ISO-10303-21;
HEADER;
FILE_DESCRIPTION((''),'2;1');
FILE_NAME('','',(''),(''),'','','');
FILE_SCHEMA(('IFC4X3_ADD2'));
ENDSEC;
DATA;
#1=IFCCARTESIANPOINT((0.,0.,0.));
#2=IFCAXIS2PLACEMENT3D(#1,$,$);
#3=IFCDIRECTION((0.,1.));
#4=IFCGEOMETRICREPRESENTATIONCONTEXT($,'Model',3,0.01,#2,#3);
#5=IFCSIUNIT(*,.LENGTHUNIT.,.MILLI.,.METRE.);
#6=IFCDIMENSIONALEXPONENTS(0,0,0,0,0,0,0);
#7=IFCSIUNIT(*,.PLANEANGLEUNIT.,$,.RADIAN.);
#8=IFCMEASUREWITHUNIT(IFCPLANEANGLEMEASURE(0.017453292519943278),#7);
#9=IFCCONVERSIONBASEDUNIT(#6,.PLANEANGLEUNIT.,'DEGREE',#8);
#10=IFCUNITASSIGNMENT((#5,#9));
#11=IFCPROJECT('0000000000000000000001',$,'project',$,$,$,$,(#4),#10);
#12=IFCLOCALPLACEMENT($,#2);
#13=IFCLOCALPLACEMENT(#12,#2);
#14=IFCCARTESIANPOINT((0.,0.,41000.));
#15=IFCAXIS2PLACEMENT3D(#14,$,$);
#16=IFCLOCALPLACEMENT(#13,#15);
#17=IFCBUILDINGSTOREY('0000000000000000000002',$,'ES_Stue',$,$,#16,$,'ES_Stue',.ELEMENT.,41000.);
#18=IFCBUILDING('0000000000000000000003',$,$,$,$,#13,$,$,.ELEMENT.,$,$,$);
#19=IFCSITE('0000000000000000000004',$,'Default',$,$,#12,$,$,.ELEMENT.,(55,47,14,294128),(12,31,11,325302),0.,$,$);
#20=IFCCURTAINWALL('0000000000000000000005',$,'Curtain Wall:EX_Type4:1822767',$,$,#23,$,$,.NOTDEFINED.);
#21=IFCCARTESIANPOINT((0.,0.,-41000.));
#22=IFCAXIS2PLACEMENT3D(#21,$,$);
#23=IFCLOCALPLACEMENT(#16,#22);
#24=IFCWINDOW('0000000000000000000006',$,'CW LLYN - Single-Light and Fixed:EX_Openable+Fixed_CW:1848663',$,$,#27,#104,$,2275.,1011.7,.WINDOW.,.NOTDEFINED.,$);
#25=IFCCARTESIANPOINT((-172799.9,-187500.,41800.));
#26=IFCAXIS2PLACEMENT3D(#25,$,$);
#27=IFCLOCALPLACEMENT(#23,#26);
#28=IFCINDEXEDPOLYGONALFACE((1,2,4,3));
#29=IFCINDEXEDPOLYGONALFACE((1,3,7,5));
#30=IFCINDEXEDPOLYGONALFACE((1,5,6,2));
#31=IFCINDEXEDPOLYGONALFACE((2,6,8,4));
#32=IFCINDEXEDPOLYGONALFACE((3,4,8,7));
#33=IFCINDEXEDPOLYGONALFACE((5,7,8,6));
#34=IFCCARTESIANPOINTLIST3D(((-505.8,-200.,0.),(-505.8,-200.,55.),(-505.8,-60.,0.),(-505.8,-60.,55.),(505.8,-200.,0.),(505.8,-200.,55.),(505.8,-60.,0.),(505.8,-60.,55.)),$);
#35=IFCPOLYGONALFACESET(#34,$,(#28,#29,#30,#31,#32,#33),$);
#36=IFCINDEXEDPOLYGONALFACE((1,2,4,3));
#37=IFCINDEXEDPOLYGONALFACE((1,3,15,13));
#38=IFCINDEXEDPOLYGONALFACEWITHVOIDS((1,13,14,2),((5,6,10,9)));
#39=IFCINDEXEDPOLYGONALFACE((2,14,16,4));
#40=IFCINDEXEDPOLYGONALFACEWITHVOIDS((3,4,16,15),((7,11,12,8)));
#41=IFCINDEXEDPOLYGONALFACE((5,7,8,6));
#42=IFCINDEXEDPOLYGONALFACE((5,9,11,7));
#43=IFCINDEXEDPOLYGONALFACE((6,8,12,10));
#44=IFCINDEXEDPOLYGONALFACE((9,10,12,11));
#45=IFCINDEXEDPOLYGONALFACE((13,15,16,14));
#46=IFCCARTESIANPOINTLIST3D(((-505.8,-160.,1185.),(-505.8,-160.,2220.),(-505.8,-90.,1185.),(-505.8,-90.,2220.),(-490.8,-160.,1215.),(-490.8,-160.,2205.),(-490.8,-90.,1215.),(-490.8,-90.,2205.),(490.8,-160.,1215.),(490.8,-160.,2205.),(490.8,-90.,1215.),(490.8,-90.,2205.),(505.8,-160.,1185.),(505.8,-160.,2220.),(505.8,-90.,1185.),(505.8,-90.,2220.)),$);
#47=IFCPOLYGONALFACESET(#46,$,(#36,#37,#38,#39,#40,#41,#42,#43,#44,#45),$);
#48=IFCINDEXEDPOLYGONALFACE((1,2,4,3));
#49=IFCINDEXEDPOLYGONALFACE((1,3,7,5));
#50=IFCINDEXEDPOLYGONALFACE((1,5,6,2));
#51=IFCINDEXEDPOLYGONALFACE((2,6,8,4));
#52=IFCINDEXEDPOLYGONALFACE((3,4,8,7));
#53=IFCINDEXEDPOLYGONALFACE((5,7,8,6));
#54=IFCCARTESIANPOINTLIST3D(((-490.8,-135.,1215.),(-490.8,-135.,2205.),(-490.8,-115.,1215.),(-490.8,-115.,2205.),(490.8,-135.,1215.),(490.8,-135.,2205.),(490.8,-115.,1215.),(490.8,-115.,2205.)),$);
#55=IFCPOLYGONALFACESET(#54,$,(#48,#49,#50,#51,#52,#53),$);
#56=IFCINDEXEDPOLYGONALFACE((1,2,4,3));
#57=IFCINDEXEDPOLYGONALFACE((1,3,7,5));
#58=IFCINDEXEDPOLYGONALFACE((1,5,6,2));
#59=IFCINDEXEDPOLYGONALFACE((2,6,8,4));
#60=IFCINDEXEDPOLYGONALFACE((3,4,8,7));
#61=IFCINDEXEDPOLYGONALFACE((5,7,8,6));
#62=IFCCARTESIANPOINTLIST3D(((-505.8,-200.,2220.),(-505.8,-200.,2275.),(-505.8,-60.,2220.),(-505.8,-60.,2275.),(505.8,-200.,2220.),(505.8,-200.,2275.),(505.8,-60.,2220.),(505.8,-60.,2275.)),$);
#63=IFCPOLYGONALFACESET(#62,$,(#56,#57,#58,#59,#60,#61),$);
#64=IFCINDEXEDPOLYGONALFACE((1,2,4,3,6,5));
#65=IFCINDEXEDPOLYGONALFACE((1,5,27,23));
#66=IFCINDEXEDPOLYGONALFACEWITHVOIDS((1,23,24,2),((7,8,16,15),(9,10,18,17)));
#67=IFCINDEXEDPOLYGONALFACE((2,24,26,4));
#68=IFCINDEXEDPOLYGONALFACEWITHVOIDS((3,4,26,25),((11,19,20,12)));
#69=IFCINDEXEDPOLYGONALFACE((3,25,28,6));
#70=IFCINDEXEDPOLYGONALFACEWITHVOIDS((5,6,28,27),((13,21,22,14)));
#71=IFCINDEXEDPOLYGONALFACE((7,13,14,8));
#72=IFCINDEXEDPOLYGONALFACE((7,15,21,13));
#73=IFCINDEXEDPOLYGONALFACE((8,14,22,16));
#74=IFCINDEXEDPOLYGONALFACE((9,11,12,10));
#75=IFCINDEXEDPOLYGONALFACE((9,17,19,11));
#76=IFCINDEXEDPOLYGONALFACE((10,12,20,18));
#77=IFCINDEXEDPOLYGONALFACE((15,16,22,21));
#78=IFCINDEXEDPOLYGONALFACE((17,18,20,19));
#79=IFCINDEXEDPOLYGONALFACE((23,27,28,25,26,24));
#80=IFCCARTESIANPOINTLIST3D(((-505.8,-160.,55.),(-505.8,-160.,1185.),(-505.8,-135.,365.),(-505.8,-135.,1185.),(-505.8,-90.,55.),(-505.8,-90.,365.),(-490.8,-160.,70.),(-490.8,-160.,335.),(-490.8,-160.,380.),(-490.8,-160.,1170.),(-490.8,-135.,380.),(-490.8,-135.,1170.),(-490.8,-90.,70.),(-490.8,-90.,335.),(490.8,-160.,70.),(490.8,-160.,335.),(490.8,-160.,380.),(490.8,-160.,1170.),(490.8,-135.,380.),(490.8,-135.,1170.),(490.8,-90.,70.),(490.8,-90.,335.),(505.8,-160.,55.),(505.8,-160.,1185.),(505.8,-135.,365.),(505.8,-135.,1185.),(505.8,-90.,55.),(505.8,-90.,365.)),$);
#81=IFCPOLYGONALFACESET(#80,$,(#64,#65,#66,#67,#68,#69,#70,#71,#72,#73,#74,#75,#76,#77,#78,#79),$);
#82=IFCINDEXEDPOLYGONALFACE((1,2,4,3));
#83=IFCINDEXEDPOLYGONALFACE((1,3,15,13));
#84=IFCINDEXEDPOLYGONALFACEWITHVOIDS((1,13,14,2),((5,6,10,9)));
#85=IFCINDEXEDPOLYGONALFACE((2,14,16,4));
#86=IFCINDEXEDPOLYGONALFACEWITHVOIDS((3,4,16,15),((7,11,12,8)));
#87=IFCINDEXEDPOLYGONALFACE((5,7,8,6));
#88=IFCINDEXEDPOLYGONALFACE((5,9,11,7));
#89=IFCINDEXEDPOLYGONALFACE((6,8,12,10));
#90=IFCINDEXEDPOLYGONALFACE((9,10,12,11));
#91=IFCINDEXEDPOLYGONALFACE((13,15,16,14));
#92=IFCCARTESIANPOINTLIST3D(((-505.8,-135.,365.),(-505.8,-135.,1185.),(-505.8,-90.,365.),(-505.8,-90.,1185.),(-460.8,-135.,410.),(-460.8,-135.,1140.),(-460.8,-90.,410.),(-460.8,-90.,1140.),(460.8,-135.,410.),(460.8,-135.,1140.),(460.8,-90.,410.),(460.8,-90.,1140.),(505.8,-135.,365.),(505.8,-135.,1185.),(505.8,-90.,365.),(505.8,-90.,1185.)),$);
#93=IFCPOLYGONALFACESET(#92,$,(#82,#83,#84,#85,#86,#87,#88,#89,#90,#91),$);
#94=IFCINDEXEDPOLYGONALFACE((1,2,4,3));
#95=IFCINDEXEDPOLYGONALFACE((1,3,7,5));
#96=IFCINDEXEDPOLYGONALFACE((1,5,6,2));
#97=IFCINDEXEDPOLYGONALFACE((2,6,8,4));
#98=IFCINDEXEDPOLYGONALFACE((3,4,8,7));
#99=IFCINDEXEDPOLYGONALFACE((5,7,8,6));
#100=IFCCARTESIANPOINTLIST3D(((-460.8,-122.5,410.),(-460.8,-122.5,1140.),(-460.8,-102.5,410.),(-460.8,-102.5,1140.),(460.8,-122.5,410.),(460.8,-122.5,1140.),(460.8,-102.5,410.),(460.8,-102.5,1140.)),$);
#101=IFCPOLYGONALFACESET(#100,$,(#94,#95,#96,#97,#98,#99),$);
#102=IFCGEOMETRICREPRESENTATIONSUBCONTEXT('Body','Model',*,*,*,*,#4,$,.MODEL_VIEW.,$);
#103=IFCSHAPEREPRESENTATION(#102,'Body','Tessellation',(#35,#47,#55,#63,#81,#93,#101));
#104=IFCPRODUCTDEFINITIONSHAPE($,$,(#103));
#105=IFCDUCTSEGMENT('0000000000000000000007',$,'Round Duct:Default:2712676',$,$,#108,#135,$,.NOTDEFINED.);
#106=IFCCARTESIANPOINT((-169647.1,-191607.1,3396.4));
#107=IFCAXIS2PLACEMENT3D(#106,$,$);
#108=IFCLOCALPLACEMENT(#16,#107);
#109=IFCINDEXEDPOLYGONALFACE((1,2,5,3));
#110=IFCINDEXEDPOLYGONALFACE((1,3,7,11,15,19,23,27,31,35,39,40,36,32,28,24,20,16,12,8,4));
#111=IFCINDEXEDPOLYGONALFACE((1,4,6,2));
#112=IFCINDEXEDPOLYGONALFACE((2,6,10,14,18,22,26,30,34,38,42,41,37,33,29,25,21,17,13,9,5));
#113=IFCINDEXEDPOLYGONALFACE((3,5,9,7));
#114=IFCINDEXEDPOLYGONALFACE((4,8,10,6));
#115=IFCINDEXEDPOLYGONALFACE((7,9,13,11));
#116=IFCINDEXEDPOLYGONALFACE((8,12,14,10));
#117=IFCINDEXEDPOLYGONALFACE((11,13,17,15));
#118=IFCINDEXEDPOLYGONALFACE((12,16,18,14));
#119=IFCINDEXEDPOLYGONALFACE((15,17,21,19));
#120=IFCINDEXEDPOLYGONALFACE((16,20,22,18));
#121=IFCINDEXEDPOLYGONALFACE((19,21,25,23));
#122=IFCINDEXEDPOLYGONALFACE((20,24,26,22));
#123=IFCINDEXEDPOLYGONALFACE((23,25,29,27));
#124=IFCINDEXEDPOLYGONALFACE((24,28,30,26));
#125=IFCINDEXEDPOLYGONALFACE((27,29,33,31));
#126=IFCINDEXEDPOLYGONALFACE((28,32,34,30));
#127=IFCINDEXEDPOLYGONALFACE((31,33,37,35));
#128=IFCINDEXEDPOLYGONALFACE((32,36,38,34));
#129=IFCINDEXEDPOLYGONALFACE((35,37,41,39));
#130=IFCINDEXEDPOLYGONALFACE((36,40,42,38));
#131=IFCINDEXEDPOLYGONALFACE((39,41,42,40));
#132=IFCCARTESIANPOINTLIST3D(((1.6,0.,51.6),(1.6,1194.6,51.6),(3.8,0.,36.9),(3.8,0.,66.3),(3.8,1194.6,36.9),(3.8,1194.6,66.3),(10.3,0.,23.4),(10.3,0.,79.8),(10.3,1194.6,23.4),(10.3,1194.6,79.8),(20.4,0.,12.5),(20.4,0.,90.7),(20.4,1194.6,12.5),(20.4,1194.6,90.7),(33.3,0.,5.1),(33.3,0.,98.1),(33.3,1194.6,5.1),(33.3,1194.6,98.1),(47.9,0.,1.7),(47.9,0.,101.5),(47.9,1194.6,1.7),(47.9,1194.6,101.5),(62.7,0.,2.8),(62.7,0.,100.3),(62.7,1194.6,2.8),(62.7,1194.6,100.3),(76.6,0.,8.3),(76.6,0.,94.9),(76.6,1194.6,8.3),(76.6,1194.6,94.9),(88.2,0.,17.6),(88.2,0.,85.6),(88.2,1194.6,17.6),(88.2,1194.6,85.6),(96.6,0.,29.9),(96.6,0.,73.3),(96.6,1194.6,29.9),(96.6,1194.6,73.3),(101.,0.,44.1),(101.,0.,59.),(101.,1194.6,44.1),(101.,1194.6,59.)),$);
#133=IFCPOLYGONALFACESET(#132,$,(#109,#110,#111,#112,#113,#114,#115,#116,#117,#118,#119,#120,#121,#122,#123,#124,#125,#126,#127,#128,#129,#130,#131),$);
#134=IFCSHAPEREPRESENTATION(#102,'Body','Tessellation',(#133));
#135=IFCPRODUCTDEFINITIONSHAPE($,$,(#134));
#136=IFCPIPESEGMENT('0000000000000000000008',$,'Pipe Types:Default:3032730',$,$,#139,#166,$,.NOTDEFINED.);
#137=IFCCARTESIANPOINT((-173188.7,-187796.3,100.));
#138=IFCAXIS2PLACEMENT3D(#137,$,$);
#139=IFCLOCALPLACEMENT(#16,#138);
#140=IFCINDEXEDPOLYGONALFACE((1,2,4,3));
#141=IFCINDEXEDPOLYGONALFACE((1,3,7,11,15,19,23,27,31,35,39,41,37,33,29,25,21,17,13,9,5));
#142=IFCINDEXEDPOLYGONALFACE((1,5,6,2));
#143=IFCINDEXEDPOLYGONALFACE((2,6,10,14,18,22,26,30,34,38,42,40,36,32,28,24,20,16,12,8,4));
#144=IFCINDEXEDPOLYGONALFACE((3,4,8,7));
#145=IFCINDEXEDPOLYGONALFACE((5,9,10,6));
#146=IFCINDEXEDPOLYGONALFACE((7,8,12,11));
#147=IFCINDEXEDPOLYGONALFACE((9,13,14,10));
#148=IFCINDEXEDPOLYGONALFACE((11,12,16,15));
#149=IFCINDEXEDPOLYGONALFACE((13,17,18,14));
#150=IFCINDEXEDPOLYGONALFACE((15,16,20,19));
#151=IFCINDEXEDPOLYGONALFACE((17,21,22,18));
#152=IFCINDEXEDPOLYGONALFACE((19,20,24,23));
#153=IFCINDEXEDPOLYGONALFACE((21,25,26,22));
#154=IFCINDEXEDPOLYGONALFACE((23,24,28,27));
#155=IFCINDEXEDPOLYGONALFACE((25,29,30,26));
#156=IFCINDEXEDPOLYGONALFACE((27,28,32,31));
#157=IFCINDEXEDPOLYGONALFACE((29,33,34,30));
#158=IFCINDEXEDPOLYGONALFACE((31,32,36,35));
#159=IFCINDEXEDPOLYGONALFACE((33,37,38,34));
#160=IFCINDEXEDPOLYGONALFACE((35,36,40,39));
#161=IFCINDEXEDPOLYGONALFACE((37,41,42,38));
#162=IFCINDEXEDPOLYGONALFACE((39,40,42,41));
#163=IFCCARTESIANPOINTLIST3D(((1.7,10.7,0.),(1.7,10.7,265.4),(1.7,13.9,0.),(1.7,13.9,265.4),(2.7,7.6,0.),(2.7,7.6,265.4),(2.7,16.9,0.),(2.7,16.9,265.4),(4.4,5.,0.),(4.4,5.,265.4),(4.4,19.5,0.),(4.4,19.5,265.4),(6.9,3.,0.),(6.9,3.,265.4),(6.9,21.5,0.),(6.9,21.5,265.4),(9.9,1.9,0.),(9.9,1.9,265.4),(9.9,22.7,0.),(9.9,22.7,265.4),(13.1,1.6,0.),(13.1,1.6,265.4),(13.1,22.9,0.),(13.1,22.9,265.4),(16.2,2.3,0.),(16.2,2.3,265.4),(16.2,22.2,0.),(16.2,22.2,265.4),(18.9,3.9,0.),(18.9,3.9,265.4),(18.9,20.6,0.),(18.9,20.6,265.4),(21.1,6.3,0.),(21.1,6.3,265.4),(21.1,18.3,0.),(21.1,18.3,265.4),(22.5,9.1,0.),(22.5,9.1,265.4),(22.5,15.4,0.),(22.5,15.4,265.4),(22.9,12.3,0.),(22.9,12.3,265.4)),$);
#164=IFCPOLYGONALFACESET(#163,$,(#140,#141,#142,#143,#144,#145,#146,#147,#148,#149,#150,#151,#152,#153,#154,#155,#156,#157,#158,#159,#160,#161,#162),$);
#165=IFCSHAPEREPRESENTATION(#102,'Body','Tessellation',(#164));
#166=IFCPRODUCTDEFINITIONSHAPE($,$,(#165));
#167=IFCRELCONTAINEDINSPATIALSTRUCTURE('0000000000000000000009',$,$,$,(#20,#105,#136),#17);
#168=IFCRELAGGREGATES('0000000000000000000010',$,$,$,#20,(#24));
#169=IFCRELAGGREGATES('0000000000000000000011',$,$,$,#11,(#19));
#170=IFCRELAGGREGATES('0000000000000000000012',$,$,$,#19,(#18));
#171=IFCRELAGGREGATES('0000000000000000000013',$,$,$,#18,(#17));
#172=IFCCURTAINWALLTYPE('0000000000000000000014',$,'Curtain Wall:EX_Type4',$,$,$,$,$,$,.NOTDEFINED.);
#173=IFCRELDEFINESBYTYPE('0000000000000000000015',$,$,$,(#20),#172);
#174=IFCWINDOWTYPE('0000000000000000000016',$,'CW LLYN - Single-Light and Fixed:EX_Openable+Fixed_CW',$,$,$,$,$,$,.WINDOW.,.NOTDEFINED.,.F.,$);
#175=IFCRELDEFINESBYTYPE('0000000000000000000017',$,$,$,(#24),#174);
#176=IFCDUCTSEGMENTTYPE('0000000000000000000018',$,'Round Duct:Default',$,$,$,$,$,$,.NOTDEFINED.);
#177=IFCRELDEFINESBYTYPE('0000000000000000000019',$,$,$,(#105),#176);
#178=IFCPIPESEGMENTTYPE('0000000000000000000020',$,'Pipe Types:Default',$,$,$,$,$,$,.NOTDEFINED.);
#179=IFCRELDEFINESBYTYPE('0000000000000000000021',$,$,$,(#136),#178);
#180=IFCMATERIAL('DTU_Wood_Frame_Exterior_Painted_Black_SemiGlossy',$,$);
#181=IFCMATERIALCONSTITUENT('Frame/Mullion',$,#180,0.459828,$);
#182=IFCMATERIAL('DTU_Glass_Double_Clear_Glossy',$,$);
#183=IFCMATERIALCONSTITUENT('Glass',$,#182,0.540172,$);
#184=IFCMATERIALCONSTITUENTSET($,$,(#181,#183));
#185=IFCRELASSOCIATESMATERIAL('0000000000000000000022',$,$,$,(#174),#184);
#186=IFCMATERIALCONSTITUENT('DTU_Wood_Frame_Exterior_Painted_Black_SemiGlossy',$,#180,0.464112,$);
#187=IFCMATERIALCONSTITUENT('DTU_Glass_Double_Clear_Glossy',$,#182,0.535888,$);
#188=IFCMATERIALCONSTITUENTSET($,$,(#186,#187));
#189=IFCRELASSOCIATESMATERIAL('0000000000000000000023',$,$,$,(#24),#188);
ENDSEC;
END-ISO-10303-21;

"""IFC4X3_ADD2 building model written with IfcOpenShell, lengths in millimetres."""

from ifc_helpers import new_model, entity, si_unit, converted_unit, direction, frame, frame_2d, origin, origin_2d_with_axis, place, context, subcontext, project, spatial, polyline, rectangle, circle, outline, extrude, source, transform, mapped, material, constituent, constituent_set, type_object, type_shapes, element, aggregate, save


model = new_model("IFC4X3_ADD2")

# Units and contexts
model_context = context("Model", 3, precision=0.01, world=origin(), true_north=direction((0.0, 1.0)))
body_context = subcontext(model_context, "Body", "Model", "MODEL_VIEW")
ifc_project = project(units=[si_unit("LENGTHUNIT", "METRE", prefix="MILLI"), converted_unit("PLANEANGLEUNIT", "DEGREE", entity("IfcPlaneAngleMeasure", 0.017453292519943278), si_unit("PLANEANGLEUNIT", "RADIAN"), dimensions=[0, 0, 0, 0, 0, 0, 0])], contexts=[model_context])

# Site, building, storey
site_placement = place(None, origin())
site = spatial("IfcSite", under=ifc_project, at=site_placement, Name="Default", CompositionType="ELEMENT", RefLatitude=(55, 47, 14, 294128), RefLongitude=(12, 31, 11, 325302), RefElevation=0.0)
building_placement = place(site_placement, origin())
building = spatial("IfcBuilding", under=site, at=building_placement, CompositionType="ELEMENT")
storey_placement = place(building_placement, frame((0.0, 0.0, 41000.0)))
storey = spatial("IfcBuildingStorey", under=building, at=storey_placement, Name="ES_Stue", LongName="ES_Stue", CompositionType="ELEMENT", Elevation=41000.0)

# Curtain wall, window, openings
curtain_wall_type = type_object("IfcCurtainWallType", Name="Curtain Wall:EX_Type4", PredefinedType="NOTDEFINED")
curtain_wall_placement = place(storey_placement, frame((0.0, 0.0, -41000.0)))
curtain_wall = element("IfcCurtainWall", 1, at=curtain_wall_placement, inside=storey, type_object=curtain_wall_type, Name="Curtain Wall:EX_Type4:1822767", PredefinedType="NOTDEFINED")
ifc_material_1 = material(Name="DTU_Wood_Frame_Exterior_Painted_Black_SemiGlossy")
ifc_material_2 = material(Name="DTU_Glass_Double_Clear_Glossy")
ifc_constituent_1 = constituent(ifc_material_1, Name="DTU_Wood_Frame_Exterior_Painted_Black_SemiGlossy", fraction=0.464112)
ifc_constituent_2 = constituent(ifc_material_2, Name="DTU_Glass_Double_Clear_Glossy", fraction=0.535888)
ifc_constituent_set_1 = constituent_set(constituents=[ifc_constituent_1, ifc_constituent_2])
ifc_constituent_3 = constituent(ifc_material_1, Name="Frame/Mullion", fraction=0.459828)
ifc_constituent_4 = constituent(ifc_material_2, Name="Glass", fraction=0.540172)
ifc_constituent_set_2 = constituent_set(constituents=[ifc_constituent_3, ifc_constituent_4])
window_type_1 = type_object("IfcWindowType", Name="CW LLYN - Single-Light and Fixed:EX_Openable+Fixed_CW", ParameterTakesPrecedence=False, PartitioningType="NOTDEFINED", PredefinedType="WINDOW", material=ifc_constituent_set_2)
shared_shape_1 = source(origin(), body_context, "Body", "SweptSolid", [
    extrude(rectangle(XDim=140.0, YDim=1011.7, at=origin_2d_with_axis()), frame((0.0, -130.0, 0.0), z_axis=(0.0, 0.0, 1.0), x_axis=(0.0, -1.0, 0.0)), (0.0, 0.0, 1.0), 55.0),
    extrude(outline(polyline([(-517.5, -505.8), (517.5, -505.8), (517.5, 505.8), (-517.5, 505.8), (-517.5, -505.8)]), holes=[polyline([(502.5, -490.8), (-487.5, -490.8), (-487.5, 490.8), (502.5, 490.8), (502.5, -490.8)])]), frame((0.0, -90.0, 1702.5), z_axis=(0.0, -1.0, 0.0), x_axis=(0.0, 0.0, 1.0)), (0.0, 0.0, 1.0), 70.0),
    extrude(rectangle(XDim=981.7, YDim=20.0, at=frame_2d((0.0, 0.0), x_axis=(1.0, 0.0))), frame((0.0, -125.0, 1215.0), z_axis=(0.0, 0.0, 1.0), x_axis=(-1.0, 0.0, 0.0)), (0.0, 0.0, 1.0), 990.0),
    extrude(rectangle(XDim=981.7, YDim=20.0, at=frame_2d((0.0, 0.0), x_axis=(1.0, 0.0))), frame((0.0, -125.0, 70.0), z_axis=(0.0, 0.0, 1.0), x_axis=(-1.0, 0.0, 0.0)), (0.0, 0.0, 1.0), 265.0),
    extrude(rectangle(XDim=140.0, YDim=1011.7, at=frame_2d((0.0, 0.0), x_axis=(1.0, 0.0))), frame((0.0, -130.0, 2220.0), z_axis=(0.0, 0.0, 1.0), x_axis=(0.0, -1.0, 0.0)), (0.0, 0.0, 1.0), 55.0),
    extrude(outline(polyline([(-38.3, -480.0), (31.7, -480.0), (31.7, 650.0), (6.7, 650.0), (6.7, -170.0), (-38.3, -170.0), (-38.3, -480.0)])), frame((505.8, -128.3, 535.0), z_axis=(-1.0, 0.0, 0.0), x_axis=(0.0, -1.0, 0.0)), (0.0, 0.0, 1.0), 1011.7),
    extrude(outline(polyline([(-410.0, -505.8), (410.0, -505.8), (410.0, 505.8), (-410.0, 505.8), (-410.0, -505.8)]), holes=[polyline([(-365.0, 460.8), (365.0, 460.8), (365.0, -460.8), (-365.0, -460.8), (-365.0, 460.8)])]), frame((0.0, -90.0, 775.0), z_axis=(0.0, -1.0, 0.0), x_axis=(0.0, 0.0, 1.0)), (0.0, 0.0, 1.0), 45.0),
    extrude(rectangle(XDim=921.7, YDim=20.0, at=frame_2d((0.0, 0.0), x_axis=(1.0, 0.0))), frame((0.0, -112.5, 410.0), z_axis=(0.0, 0.0, 1.0), x_axis=(-1.0, 0.0, 0.0)), (0.0, 0.0, 1.0), 730.0),
])
type_shapes(window_type_1, [shared_shape_1])
window_1_placement = place(curtain_wall_placement, frame((-172799.9, -187500.0, 41800.0)))
window_1 = element("IfcWindow", 2, at=window_1_placement, type_object=window_type_1, material=ifc_constituent_set_1, Name="CW LLYN - Single-Light and Fixed:EX_Openable+Fixed_CW:1848663", OverallHeight=2275.0, OverallWidth=1011.7, PartitioningType="NOTDEFINED", PredefinedType="WINDOW", context=body_context, shape_type="MappedRepresentation", body=[
    mapped(shared_shape_1, transform((0.0, 0.0, 0.0), scale=1.0)),
])
opening_1_placement = place(curtain_wall_placement, frame((-172799.9, -187500.0, 82800.0), z_axis=(0.0, 0.0, 1.0), x_axis=(-1.0, 0.0, 0.0)))
opening_1 = element("IfcOpeningElement", 3, at=opening_1_placement, cuts=window_1, PredefinedType="OPENING", context=body_context, shape_type="SweptSolid", body=[
    extrude(rectangle(XDim=265.0, YDim=981.7, at=frame_2d((0.0, 0.0), x_axis=(1.0, 0.0))), frame((0.0, 160.0, -40797.5), z_axis=(0.0, -1.0, 0.0), x_axis=(0.0, 0.0, 1.0)), (0.0, 0.0, 1.0), 70.0),
])
opening_2_placement = place(curtain_wall_placement, frame((-172799.9, -187500.0, 82800.0), z_axis=(0.0, 0.0, 1.0), x_axis=(-1.0, 0.0, 0.0)))
opening_2 = element("IfcOpeningElement", 4, at=opening_2_placement, cuts=window_1, PredefinedType="OPENING", context=body_context, shape_type="SweptSolid", body=[
    extrude(rectangle(XDim=790.0, YDim=981.7, at=frame_2d((0.0, 0.0), x_axis=(1.0, 0.0))), frame((0.0, 135.0, -40225.0), z_axis=(0.0, 1.0, 0.0), x_axis=(0.0, 0.0, 1.0)), (0.0, 0.0, 1.0), 25.0),
])
aggregate(curtain_wall, [window_1, opening_1, opening_2])

# Duct segment
duct_segment_type = type_object("IfcDuctSegmentType", Name="Round Duct:Default", PredefinedType="NOTDEFINED")
duct_segment_placement = place(storey_placement, frame((-169647.1, -191607.1, 3396.4)))
element("IfcDuctSegment", 5, at=duct_segment_placement, inside=storey, type_object=duct_segment_type, Name="Round Duct:Default:2712676", PredefinedType="NOTDEFINED", context=body_context, shape_type="SweptSolid", body=[
    extrude(circle(Radius=50.0, at=origin_2d_with_axis()), frame((51.6, 0.0, 51.6), z_axis=(0.0, 1.0, 0.0), x_axis=(-1.0, 0.0, 0.0)), (0.0, 0.0, 1.0), 1194.6),
])

# Pipe segment
pipe_segment_type = type_object("IfcPipeSegmentType", Name="Pipe Types:Default", PredefinedType="NOTDEFINED")
for number, where, name in (
    (6, (-173188.7, -187796.3, 100.0), "Pipe Types:Default:3032730"),
):
    element("IfcPipeSegment", number, at=place(storey_placement, frame(where)), inside=storey, type_object=pipe_segment_type, Name=name, PredefinedType="NOTDEFINED", context=body_context, shape_type="SweptSolid", body=[
        extrude(circle(Radius=10.7, at=origin_2d_with_axis()), frame((12.3, 12.3, 0.0)), (0.0, 0.0, 1.0), 265.4),
    ])

save(model, "model.ifc")
